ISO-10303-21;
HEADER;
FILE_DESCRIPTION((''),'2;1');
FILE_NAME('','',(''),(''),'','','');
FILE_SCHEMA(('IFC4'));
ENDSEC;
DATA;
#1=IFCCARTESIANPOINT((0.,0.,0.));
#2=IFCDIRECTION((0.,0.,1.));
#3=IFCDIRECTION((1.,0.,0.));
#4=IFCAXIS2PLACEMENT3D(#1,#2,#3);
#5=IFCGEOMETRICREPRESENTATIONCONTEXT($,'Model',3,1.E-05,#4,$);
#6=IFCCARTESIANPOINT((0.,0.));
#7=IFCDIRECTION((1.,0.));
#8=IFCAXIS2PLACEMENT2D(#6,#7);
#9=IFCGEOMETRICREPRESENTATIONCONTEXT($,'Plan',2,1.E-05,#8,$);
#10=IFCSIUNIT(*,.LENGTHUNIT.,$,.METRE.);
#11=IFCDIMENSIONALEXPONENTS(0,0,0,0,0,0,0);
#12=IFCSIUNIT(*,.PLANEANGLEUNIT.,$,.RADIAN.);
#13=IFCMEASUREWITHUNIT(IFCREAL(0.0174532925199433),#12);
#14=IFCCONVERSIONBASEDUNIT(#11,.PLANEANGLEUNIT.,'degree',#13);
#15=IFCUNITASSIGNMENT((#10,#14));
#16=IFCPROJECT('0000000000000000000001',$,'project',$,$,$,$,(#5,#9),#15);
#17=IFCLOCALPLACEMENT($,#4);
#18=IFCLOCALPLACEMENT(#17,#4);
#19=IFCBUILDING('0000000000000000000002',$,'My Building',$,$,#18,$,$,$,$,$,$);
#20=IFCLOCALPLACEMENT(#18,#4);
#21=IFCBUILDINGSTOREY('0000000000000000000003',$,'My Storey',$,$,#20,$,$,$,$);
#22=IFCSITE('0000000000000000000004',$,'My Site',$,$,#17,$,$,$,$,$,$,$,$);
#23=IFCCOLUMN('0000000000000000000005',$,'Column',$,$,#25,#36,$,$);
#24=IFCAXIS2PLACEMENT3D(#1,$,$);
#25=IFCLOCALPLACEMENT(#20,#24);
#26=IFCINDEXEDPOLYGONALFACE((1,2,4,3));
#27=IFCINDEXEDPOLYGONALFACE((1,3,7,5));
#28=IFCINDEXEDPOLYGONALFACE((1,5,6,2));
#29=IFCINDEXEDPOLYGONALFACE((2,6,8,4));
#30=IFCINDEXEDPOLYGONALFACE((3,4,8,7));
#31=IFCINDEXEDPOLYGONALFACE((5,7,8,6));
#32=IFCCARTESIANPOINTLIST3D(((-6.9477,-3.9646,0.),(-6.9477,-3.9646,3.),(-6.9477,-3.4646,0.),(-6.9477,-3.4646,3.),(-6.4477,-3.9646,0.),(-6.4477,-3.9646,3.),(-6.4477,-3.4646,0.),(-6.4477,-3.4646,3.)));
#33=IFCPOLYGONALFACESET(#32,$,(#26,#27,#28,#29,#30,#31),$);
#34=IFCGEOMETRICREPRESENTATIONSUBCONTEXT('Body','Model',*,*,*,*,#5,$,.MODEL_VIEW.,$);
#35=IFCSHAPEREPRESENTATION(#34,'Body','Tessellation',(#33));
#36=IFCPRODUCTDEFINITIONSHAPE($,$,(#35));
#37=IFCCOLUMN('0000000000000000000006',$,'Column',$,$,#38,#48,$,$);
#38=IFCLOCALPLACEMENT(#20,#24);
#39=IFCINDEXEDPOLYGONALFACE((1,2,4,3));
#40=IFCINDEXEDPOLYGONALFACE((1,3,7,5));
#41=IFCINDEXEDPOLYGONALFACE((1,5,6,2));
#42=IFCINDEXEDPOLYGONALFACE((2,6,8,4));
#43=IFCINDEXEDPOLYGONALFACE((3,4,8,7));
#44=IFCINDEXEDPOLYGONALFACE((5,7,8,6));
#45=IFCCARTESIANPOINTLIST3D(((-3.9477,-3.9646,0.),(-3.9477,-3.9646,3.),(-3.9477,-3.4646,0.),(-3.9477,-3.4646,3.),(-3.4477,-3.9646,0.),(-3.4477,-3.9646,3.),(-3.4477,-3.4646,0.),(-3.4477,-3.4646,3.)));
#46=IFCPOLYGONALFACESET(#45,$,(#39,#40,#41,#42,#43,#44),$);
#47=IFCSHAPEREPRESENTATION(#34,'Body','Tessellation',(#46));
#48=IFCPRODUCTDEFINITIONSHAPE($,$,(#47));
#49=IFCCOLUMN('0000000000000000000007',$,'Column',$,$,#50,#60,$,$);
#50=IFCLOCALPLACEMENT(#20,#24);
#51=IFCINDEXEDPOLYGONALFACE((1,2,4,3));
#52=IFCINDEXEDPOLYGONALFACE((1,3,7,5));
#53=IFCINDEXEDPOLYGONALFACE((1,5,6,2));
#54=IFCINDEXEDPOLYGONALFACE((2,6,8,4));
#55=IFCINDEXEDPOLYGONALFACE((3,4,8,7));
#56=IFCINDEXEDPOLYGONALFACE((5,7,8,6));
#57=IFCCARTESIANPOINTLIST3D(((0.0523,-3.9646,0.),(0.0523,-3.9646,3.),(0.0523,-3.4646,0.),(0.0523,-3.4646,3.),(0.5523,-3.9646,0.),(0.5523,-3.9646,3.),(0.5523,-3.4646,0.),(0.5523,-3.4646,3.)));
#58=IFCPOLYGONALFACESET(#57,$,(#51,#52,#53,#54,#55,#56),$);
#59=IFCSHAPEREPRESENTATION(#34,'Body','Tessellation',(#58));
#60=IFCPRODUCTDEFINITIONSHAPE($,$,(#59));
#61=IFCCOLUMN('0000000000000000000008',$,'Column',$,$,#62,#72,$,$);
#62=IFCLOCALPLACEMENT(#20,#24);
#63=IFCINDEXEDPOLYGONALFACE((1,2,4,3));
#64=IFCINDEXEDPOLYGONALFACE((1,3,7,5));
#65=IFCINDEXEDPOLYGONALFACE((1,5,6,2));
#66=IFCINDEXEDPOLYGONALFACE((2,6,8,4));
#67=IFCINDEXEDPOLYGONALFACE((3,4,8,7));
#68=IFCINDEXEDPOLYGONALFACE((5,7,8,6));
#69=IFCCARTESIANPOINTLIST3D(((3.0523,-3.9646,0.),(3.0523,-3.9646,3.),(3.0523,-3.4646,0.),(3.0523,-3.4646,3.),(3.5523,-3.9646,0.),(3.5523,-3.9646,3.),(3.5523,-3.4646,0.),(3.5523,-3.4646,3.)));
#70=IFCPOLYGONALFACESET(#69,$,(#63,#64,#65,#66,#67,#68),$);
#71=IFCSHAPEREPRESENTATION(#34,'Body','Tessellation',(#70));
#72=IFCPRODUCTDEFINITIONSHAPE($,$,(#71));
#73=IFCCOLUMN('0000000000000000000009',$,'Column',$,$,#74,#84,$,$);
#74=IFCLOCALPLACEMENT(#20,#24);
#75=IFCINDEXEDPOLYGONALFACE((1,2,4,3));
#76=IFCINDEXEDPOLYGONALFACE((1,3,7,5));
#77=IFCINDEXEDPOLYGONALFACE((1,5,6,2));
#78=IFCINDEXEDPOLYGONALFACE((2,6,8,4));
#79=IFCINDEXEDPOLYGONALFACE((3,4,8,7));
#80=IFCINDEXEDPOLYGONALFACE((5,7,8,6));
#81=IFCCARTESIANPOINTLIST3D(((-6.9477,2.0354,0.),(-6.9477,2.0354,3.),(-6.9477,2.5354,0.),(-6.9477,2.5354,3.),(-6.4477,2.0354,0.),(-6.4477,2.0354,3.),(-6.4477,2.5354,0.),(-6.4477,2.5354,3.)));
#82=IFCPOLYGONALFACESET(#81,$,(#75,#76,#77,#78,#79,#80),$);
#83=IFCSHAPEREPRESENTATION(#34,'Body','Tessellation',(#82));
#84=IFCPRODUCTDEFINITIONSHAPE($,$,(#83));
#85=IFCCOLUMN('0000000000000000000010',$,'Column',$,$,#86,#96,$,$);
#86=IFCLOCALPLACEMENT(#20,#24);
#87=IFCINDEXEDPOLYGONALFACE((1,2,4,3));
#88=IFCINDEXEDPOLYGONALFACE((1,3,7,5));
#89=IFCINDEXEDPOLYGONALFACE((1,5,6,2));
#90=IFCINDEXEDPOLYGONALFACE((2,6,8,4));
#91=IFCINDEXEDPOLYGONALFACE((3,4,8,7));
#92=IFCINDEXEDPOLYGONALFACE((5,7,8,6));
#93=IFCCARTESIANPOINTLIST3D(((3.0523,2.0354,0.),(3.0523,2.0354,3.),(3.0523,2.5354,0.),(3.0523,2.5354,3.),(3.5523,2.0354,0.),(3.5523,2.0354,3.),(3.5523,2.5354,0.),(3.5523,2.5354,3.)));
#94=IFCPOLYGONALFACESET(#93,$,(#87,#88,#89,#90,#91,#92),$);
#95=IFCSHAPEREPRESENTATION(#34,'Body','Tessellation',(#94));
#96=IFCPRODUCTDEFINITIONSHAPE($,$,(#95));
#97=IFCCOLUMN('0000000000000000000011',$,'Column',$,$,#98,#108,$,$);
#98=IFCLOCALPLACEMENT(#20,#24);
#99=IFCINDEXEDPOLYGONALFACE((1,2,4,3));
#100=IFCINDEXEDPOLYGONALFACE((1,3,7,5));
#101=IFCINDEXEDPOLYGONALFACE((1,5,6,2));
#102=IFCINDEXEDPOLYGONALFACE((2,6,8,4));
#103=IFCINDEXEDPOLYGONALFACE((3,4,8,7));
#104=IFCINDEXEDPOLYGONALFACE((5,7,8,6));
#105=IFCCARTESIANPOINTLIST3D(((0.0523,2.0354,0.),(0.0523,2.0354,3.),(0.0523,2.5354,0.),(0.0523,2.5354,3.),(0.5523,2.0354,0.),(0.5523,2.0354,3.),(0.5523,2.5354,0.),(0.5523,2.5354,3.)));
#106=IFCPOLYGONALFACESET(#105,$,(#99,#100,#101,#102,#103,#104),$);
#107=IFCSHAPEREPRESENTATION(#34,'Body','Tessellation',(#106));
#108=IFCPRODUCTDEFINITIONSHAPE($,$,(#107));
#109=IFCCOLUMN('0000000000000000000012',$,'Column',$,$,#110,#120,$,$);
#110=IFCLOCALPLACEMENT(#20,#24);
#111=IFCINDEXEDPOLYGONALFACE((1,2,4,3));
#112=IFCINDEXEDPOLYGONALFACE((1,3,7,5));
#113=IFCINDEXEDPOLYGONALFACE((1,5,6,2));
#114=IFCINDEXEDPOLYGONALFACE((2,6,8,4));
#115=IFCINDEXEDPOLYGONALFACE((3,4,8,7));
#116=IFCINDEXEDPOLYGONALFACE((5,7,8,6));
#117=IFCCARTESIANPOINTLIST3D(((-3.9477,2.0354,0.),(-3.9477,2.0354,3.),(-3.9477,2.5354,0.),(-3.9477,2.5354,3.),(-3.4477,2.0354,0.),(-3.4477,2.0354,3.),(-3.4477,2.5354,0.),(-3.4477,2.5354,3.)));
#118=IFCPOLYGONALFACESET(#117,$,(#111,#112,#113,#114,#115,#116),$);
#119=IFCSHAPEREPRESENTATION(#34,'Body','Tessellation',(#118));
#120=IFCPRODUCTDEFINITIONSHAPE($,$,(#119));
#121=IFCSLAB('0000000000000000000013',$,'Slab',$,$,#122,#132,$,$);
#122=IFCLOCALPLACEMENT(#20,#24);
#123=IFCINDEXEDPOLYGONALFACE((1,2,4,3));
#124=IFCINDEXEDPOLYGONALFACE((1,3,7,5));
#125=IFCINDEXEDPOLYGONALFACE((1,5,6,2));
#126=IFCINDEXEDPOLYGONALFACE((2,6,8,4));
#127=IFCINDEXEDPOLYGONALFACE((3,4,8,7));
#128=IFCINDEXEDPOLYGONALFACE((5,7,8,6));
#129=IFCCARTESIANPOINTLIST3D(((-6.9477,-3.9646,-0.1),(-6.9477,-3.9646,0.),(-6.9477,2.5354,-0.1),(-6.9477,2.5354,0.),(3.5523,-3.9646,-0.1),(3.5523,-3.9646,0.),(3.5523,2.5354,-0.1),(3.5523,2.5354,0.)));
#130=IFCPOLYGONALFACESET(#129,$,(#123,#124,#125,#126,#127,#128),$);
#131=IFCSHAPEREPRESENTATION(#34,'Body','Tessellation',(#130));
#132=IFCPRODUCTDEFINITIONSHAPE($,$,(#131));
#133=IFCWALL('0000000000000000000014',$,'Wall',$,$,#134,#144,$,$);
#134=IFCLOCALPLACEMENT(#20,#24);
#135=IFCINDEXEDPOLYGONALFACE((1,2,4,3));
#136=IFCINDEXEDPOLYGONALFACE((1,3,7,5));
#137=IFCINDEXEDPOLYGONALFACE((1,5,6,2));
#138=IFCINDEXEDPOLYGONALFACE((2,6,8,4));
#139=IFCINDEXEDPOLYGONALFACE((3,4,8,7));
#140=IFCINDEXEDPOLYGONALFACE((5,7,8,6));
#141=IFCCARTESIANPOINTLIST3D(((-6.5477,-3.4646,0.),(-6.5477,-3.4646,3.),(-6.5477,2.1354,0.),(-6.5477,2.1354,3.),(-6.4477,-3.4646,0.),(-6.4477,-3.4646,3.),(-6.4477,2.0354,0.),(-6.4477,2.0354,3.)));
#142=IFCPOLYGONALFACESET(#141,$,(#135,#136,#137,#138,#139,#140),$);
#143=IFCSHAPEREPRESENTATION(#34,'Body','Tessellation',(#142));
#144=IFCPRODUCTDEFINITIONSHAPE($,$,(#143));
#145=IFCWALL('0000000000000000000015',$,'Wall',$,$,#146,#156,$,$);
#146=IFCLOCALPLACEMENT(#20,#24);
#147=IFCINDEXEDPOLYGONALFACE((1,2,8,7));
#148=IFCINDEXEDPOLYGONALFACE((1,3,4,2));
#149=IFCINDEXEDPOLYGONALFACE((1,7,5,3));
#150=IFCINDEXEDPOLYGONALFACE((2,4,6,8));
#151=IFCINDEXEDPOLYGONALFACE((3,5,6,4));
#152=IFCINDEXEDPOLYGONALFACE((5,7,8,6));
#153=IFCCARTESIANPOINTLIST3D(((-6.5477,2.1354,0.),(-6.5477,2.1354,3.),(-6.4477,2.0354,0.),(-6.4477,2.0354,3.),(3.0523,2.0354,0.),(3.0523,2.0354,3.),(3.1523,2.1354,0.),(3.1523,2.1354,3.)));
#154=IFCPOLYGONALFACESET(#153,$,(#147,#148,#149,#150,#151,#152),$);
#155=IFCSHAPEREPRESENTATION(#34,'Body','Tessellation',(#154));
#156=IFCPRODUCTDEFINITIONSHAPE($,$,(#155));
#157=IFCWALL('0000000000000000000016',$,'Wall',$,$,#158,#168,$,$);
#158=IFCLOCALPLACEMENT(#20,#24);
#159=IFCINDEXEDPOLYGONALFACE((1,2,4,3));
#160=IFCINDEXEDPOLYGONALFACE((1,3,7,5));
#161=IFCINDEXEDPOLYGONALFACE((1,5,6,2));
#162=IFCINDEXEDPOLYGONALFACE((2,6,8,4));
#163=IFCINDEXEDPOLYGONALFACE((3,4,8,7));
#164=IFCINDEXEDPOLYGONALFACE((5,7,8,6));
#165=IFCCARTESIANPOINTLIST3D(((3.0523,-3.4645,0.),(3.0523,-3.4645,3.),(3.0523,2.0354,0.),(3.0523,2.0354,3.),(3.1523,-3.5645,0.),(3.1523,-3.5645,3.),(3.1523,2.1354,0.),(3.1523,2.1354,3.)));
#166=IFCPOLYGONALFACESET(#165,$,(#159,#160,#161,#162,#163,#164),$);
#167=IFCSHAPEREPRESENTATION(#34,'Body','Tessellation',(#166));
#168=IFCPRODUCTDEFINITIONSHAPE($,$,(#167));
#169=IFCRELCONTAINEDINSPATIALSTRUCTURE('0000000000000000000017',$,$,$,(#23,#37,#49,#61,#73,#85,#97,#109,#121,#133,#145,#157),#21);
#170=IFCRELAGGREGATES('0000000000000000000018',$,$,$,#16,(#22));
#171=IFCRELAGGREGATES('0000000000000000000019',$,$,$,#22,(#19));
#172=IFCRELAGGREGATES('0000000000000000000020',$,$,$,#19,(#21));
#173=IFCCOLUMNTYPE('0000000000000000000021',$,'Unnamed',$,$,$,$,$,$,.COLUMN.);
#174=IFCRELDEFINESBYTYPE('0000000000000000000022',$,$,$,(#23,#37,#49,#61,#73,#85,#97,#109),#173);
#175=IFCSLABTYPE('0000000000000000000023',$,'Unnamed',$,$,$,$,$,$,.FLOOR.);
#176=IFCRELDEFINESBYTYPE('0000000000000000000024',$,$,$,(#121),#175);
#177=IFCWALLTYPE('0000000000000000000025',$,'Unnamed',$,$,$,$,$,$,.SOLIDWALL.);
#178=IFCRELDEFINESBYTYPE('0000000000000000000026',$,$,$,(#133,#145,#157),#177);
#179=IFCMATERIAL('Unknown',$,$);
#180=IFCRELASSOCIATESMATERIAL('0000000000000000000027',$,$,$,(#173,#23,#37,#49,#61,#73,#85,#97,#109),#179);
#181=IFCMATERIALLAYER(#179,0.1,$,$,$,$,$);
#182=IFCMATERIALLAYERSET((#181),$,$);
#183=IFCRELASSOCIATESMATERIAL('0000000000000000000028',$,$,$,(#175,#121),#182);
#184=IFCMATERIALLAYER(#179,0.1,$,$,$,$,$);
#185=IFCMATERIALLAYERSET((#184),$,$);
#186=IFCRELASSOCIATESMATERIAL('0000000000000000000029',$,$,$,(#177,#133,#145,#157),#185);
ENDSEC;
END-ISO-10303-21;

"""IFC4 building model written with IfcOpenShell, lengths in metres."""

from ifc_helpers import new_model, entity, si_unit, converted_unit, frame, origin_with_axes, origin_2d_with_axis, place, context, subcontext, project, spatial, line, indexed_curve, rectangle, outline, extrude, material, layer, layer_set, layer_usage, material_profile, profile_set, profile_usage, type_object, element, save


model = new_model("IFC4")

# Units and contexts
model_context = context("Model", 3, precision=1e-05, world=origin_with_axes())
plan_context = context("Plan", 2, precision=1e-05, world=origin_2d_with_axis())
body_context_1 = subcontext(model_context, "Body", "Model", "MODEL_VIEW")
ifc_project = project(units=[si_unit("LENGTHUNIT", "METRE"), converted_unit("PLANEANGLEUNIT", "degree", entity("IfcReal", 0.0174532925199433), si_unit("PLANEANGLEUNIT", "RADIAN"), dimensions=[0, 0, 0, 0, 0, 0, 0])], contexts=[model_context, plan_context])

# Site, building, storey
site_placement = place(None, origin_with_axes())
site = spatial("IfcSite", under=ifc_project, at=site_placement, Name="My Site")
building_placement = place(site_placement, origin_with_axes())
building = spatial("IfcBuilding", under=site, at=building_placement, Name="My Building")
storey_placement = place(building_placement, origin_with_axes())
storey = spatial("IfcBuildingStorey", under=building, at=storey_placement, Name="My Storey")

# Columns
ifc_material = material(Name="Unknown")
ifc_material_profile = material_profile(ifc_material, rectangle(XDim=0.5, YDim=0.5))
ifc_profile_set = profile_set([ifc_material_profile])
ifc_profile_usage_1 = profile_usage(ifc_profile_set, cardinal=5)
column_type = type_object("IfcColumnType", Name="Unnamed", PredefinedType="COLUMN", material=ifc_profile_set)
column_1_placement = place(storey_placement, frame((-6.6977, -3.7146, 0.0), z_axis=(0.0, 0.0, 1.0), x_axis=(1.0, 0.0, 0.0)))
element("IfcColumn", 1, at=column_1_placement, inside=storey, type_object=column_type, material=ifc_profile_usage_1, Name="Column", context=body_context_1, shape_type="SweptSolid", body=[
    extrude(rectangle(XDim=0.5, YDim=0.5), origin_with_axes(), (0.0, 0.0, 1.0), 3.0),
])
ifc_profile_usage_2 = profile_usage(ifc_profile_set, cardinal=5)
column_2_placement = place(storey_placement, frame((-3.6977, -3.7146, 0.0), z_axis=(0.0, 0.0, 1.0), x_axis=(1.0, 0.0, 0.0)))
element("IfcColumn", 2, at=column_2_placement, inside=storey, type_object=column_type, material=ifc_profile_usage_2, Name="Column", context=body_context_1, shape_type="SweptSolid", body=[
    extrude(rectangle(XDim=0.5, YDim=0.5), origin_with_axes(), (0.0, 0.0, 1.0), 3.0),
])
ifc_profile_usage_3 = profile_usage(ifc_profile_set, cardinal=5)
column_3_placement = place(storey_placement, frame((0.3023, -3.7146, 0.0), z_axis=(0.0, 0.0, 1.0), x_axis=(1.0, 0.0, 0.0)))
element("IfcColumn", 3, at=column_3_placement, inside=storey, type_object=column_type, material=ifc_profile_usage_3, Name="Column", context=body_context_1, shape_type="SweptSolid", body=[
    extrude(rectangle(XDim=0.5, YDim=0.5), origin_with_axes(), (0.0, 0.0, 1.0), 3.0),
])
ifc_profile_usage_4 = profile_usage(ifc_profile_set, cardinal=5)
column_4_placement = place(storey_placement, frame((3.3023, -3.7146, 0.0), z_axis=(0.0, 0.0, 1.0), x_axis=(1.0, 0.0, 0.0)))
element("IfcColumn", 4, at=column_4_placement, inside=storey, type_object=column_type, material=ifc_profile_usage_4, Name="Column", context=body_context_1, shape_type="SweptSolid", body=[
    extrude(rectangle(XDim=0.5, YDim=0.5), origin_with_axes(), (0.0, 0.0, 1.0), 3.0),
])
ifc_profile_usage_5 = profile_usage(ifc_profile_set, cardinal=5)
column_5_placement = place(storey_placement, frame((-6.6977, 2.2854, 0.0), z_axis=(0.0, 0.0, 1.0), x_axis=(1.0, 0.0, 0.0)))
element("IfcColumn", 5, at=column_5_placement, inside=storey, type_object=column_type, material=ifc_profile_usage_5, Name="Column", context=body_context_1, shape_type="SweptSolid", body=[
    extrude(rectangle(XDim=0.5, YDim=0.5), origin_with_axes(), (0.0, 0.0, 1.0), 3.0),
])
ifc_profile_usage_6 = profile_usage(ifc_profile_set, cardinal=5)
column_6_placement = place(storey_placement, frame((3.3023, 2.2854, 0.0), z_axis=(0.0, 0.0, 1.0), x_axis=(1.0, 0.0, 0.0)))
element("IfcColumn", 6, at=column_6_placement, inside=storey, type_object=column_type, material=ifc_profile_usage_6, Name="Column", context=body_context_1, shape_type="SweptSolid", body=[
    extrude(rectangle(XDim=0.5, YDim=0.5), origin_with_axes(), (0.0, 0.0, 1.0), 3.0),
])
ifc_profile_usage_7 = profile_usage(ifc_profile_set, cardinal=5)
column_7_placement = place(storey_placement, frame((0.3023, 2.2854, 0.0), z_axis=(0.0, 0.0, 1.0), x_axis=(1.0, 0.0, 0.0)))
element("IfcColumn", 7, at=column_7_placement, inside=storey, type_object=column_type, material=ifc_profile_usage_7, Name="Column", context=body_context_1, shape_type="SweptSolid", body=[
    extrude(rectangle(XDim=0.5, YDim=0.5), origin_with_axes(), (0.0, 0.0, 1.0), 3.0),
])
ifc_profile_usage_8 = profile_usage(ifc_profile_set, cardinal=5)
column_8_placement = place(storey_placement, frame((-3.6977, 2.2854, 0.0), z_axis=(0.0, 0.0, 1.0), x_axis=(1.0, 0.0, 0.0)))
element("IfcColumn", 8, at=column_8_placement, inside=storey, type_object=column_type, material=ifc_profile_usage_8, Name="Column", context=body_context_1, shape_type="SweptSolid", body=[
    extrude(rectangle(XDim=0.5, YDim=0.5), origin_with_axes(), (0.0, 0.0, 1.0), 3.0),
])

# Slab
ifc_layer_1 = layer(ifc_material, 0.1)
ifc_layer_set_1 = layer_set([ifc_layer_1])
ifc_layer_usage_1 = layer_usage(ifc_layer_set_1, "AXIS3", "POSITIVE", -0.1)
slab_type = type_object("IfcSlabType", Name="Unnamed", PredefinedType="FLOOR", material=ifc_layer_set_1)
slab_placement = place(storey_placement, frame((-6.9477, 2.5354, 0.0), z_axis=(0.0, 0.0, 1.0), x_axis=(1.0, 0.0, 0.0)))
element("IfcSlab", 9, at=slab_placement, inside=storey, type_object=slab_type, material=ifc_layer_usage_1, Name="Slab", context=body_context_1, shape_type="SweptSolid", body=[
    extrude(outline(indexed_curve([(0.0, 0.0), (10.5, 0.0), (10.5, -6.5), (0.0, -6.5), (0.0, 0.0)])), frame((0.0, 0.0, -0.1), z_axis=(0.0, 0.0, 1.0), x_axis=(1.0, 0.0, 0.0)), (0.0, 0.0, 1.0), 0.1),
])

# Walls
ifc_layer_2 = layer(ifc_material, 0.1)
ifc_layer_set_2 = layer_set([ifc_layer_2])
ifc_layer_usage_2 = layer_usage(ifc_layer_set_2, "AXIS2", "POSITIVE", 0.0)
wall_type = type_object("IfcWallType", Name="Unnamed", PredefinedType="SOLIDWALL", material=ifc_layer_set_2)
wall_1_placement = place(storey_placement, frame((-6.4477, -3.4646, 0.0), z_axis=(0.0, 0.0, 1.0), x_axis=(0.0, 1.0, 0.0)))
element("IfcWall", 10, at=wall_1_placement, inside=storey, type_object=wall_type, material=ifc_layer_usage_2, Name="Wall", context=body_context_1, shape_type="SweptSolid", body=[
    extrude(outline(indexed_curve([(0.0, 0.0), (0.0, 0.1), (5.6, 0.1), (5.5, 0.0)], segments=[line(1, 2, 3, 4, 1)])), origin_with_axes(), (0.0, 0.0, 1.0), 3.0),
])
ifc_layer_usage_3 = layer_usage(ifc_layer_set_2, "AXIS2", "POSITIVE", 0.0)
wall_2_placement = place(storey_placement, frame((-6.4477, 2.0354, 0.0), z_axis=(0.0, 0.0, 1.0), x_axis=(1.0, 0.0, 0.0)))
element("IfcWall", 11, at=wall_2_placement, inside=storey, type_object=wall_type, material=ifc_layer_usage_3, Name="Wall", context=body_context_1, shape_type="SweptSolid", body=[
    extrude(outline(indexed_curve([(0.0, 0.0), (-0.1, 0.1), (9.6, 0.1), (9.5, 0.0)], segments=[line(1, 2, 3, 4, 1)])), origin_with_axes(), (0.0, 0.0, 1.0), 3.0),
])
ifc_layer_usage_4 = layer_usage(ifc_layer_set_2, "AXIS2", "POSITIVE", 0.0)
wall_3_placement = place(storey_placement, frame((3.0523, 2.0354, 0.0), z_axis=(0.0, 0.0, 1.0), x_axis=(0.0, -1.0, 0.0)))
element("IfcWall", 12, at=wall_3_placement, inside=storey, type_object=wall_type, material=ifc_layer_usage_4, Name="Wall", context=body_context_1, shape_type="SweptSolid", body=[
    extrude(outline(indexed_curve([(0.0, 0.0), (-0.1, 0.1), (5.5999, 0.1), (5.4999, 0.0)], segments=[line(1, 2, 3, 4, 1)])), origin_with_axes(), (0.0, 0.0, 1.0), 3.0),
])

save(model, "model.ifc")
